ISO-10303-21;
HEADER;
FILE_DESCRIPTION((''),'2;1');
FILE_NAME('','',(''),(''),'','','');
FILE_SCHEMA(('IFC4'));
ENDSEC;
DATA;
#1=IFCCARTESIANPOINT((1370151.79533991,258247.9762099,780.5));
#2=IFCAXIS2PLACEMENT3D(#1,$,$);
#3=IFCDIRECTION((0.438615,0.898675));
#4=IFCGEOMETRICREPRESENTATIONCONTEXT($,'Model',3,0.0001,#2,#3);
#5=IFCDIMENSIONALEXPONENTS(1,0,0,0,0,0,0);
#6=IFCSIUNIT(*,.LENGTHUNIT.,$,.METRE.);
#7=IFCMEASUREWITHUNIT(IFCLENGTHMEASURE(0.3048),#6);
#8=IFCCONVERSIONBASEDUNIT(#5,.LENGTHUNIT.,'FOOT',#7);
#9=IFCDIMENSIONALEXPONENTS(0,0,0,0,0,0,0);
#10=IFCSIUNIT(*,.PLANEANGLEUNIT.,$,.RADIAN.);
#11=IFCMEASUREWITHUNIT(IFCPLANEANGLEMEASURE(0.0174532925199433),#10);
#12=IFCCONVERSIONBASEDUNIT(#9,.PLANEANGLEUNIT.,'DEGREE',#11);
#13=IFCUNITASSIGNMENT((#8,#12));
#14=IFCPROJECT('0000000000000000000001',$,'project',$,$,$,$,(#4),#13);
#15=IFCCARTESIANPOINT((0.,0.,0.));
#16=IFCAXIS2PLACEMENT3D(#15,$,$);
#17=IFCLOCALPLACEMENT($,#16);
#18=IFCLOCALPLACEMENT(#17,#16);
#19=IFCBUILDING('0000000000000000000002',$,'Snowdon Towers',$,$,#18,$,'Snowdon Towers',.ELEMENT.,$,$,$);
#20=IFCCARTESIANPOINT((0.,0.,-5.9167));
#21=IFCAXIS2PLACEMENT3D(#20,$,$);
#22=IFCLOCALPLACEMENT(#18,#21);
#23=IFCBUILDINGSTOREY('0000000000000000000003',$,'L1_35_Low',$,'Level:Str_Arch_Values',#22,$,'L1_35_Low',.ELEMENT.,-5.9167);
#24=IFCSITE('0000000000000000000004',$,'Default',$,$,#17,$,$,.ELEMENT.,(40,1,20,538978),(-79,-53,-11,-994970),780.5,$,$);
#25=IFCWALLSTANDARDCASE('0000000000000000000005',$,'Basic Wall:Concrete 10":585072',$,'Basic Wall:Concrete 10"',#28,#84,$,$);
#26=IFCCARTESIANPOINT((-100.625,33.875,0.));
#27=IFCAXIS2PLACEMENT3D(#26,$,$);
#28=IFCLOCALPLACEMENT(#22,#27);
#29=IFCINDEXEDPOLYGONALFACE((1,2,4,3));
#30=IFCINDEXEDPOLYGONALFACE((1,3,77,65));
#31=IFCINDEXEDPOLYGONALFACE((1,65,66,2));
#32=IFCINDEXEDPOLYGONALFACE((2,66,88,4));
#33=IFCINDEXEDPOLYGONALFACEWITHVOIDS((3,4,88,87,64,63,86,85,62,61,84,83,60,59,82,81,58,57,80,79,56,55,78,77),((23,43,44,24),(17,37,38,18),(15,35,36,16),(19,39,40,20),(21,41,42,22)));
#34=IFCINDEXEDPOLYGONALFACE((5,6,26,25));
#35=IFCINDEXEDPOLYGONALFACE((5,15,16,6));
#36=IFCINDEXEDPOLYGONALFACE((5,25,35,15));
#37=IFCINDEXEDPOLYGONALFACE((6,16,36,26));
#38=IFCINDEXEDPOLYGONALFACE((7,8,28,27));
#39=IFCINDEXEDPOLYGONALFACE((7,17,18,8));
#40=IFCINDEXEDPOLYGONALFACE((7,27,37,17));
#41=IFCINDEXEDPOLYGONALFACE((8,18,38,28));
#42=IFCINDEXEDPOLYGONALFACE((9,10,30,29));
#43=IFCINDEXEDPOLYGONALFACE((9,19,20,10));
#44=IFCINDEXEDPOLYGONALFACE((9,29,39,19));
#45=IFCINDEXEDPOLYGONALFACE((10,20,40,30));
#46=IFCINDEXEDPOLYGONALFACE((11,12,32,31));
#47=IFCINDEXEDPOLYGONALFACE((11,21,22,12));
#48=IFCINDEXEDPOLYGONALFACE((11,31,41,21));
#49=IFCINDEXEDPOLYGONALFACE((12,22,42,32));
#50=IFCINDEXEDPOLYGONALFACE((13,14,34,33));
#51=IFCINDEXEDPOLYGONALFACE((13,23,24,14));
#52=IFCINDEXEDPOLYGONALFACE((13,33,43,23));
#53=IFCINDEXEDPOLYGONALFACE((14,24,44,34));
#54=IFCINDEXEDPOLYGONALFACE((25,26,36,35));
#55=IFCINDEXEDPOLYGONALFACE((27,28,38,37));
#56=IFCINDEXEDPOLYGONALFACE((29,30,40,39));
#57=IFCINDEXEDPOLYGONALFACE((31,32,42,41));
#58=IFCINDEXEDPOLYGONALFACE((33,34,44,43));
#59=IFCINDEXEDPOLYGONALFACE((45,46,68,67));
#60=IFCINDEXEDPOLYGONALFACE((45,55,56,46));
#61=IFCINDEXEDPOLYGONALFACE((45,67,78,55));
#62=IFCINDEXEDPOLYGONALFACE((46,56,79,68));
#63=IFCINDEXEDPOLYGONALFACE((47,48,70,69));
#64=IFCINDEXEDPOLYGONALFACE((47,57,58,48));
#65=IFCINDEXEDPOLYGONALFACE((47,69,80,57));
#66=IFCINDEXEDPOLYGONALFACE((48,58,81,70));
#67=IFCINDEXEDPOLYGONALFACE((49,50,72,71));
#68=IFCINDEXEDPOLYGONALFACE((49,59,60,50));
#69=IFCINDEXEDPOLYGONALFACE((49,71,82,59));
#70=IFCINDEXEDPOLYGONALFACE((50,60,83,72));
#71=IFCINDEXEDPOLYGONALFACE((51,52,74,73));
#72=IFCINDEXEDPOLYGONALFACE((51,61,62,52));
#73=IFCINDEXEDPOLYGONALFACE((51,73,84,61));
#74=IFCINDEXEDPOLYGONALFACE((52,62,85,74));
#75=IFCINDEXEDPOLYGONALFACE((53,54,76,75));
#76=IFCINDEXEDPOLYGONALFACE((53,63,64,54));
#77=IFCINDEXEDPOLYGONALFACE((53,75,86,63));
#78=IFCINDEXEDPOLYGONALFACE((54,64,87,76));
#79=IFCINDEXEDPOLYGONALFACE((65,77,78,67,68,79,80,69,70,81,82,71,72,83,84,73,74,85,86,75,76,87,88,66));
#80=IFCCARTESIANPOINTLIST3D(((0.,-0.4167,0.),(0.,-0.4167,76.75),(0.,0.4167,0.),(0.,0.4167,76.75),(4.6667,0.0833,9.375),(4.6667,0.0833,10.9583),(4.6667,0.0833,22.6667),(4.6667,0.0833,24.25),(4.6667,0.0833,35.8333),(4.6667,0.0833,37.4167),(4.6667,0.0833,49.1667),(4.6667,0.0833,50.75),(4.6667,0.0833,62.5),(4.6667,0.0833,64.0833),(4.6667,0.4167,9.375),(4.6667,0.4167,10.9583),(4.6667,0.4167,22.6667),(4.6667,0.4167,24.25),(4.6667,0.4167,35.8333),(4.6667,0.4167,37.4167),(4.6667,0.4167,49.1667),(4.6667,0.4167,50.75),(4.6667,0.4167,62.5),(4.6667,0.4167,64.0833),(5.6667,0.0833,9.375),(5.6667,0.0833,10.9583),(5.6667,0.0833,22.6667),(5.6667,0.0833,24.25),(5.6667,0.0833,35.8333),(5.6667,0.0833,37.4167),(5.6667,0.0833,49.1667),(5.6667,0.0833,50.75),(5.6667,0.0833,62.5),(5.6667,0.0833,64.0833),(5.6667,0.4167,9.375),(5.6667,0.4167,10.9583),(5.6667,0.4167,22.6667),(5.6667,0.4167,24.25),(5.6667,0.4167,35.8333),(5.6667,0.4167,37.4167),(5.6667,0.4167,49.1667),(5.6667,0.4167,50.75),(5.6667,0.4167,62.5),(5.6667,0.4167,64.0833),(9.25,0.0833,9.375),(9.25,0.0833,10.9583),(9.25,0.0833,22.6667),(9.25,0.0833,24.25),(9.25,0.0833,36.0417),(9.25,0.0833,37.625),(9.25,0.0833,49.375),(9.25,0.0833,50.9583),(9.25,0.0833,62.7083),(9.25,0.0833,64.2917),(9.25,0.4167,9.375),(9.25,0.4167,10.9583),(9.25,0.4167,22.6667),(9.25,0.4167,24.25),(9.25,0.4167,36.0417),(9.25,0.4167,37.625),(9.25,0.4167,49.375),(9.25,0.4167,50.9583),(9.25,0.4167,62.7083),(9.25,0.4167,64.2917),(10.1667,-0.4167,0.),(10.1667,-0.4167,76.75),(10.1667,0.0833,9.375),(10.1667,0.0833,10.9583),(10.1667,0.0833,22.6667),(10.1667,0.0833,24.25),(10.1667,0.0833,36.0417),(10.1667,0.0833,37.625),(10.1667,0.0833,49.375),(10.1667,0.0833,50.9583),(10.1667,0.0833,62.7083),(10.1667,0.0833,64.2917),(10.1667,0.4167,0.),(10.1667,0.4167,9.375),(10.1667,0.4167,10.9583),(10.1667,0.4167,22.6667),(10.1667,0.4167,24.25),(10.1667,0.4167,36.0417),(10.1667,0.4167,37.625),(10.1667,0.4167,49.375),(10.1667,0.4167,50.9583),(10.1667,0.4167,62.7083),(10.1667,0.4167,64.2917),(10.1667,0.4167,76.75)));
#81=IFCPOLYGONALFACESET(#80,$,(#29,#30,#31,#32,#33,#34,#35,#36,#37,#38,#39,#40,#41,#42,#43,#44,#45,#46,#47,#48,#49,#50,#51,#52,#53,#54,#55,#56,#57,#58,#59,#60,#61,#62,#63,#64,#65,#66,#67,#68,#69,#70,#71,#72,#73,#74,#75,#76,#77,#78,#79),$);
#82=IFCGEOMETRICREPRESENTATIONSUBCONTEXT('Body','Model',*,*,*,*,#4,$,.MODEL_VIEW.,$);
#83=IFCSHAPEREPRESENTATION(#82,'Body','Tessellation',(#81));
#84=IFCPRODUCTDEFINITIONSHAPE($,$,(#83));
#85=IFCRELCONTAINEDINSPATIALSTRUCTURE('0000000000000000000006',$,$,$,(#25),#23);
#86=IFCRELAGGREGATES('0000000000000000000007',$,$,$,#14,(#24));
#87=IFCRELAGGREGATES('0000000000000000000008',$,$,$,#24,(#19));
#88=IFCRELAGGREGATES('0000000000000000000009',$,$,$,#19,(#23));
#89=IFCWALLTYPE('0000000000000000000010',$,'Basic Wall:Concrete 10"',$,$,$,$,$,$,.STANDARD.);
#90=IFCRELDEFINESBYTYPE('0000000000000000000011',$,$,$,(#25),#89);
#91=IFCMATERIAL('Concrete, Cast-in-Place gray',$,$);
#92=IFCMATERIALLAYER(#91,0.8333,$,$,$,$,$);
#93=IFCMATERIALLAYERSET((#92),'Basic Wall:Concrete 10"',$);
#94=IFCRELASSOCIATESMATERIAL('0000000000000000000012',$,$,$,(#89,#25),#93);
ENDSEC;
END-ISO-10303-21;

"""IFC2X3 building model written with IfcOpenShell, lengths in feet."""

from ifc_helpers import new_model, entity, si_unit, converted_unit, direction, frame, frame_2d, origin, place, context, subcontext, project, spatial, rectangle, extrude, material, layer, layer_set, layer_usage, type_object, element, save


model = new_model("IFC2X3")

# Units and contexts
model_context = context("Model", 3, precision=0.0001, world=frame((1370151.79533991, 258247.9762099, 780.5)), true_north=direction((0.438615, 0.898675)))
body_context = subcontext(model_context, "Body", "Model", "MODEL_VIEW")
ifc_project = project(units=[converted_unit("LENGTHUNIT", "FOOT", entity("IfcLengthMeasure", 0.3048), si_unit("LENGTHUNIT", "METRE"), dimensions=[1, 0, 0, 0, 0, 0, 0]), converted_unit("PLANEANGLEUNIT", "DEGREE", entity("IfcPlaneAngleMeasure", 0.0174532925199433), si_unit("PLANEANGLEUNIT", "RADIAN"), dimensions=[0, 0, 0, 0, 0, 0, 0])], contexts=[model_context])

# Site, building, storey
site_placement = place(None, origin())
site = spatial("IfcSite", under=ifc_project, at=site_placement, Name="Default", CompositionType="ELEMENT", RefLatitude=(40, 1, 20, 538978), RefLongitude=(-79, -53, -11, -994970), RefElevation=780.5)
building_placement = place(site_placement, origin())
building = spatial("IfcBuilding", under=site, at=building_placement, Name="Snowdon Towers", LongName="Snowdon Towers", CompositionType="ELEMENT")
storey_placement = place(building_placement, frame((0.0, 0.0, -5.9167)))
storey = spatial("IfcBuildingStorey", under=building, at=storey_placement, Name="L1_35_Low", ObjectType="Level:Str_Arch_Values", LongName="L1_35_Low", CompositionType="ELEMENT", Elevation=-5.9167)

# Wall, openings
ifc_material_1 = material(Name="Concrete, Cast-in-Place gray")
ifc_layer = layer(ifc_material_1, 0.8333)
ifc_layer_set = layer_set([ifc_layer], Name="Basic Wall:Concrete 10\"")
ifc_layer_usage_1 = layer_usage(ifc_layer_set, "AXIS2", "POSITIVE", -0.4167)
wall_type = type_object("IfcWallType", Name="Basic Wall:Concrete 10\"", PredefinedType="STANDARD", material=ifc_layer_set)
wall_1_placement = place(storey_placement, frame((-100.625, 33.875, 0.0)))
wall_1 = element("IfcWallStandardCase", 1, at=wall_1_placement, inside=storey, type_object=wall_type, material=ifc_layer_usage_1, Name="Basic Wall:Concrete 10\":585072", ObjectType="Basic Wall:Concrete 10\"", context=body_context, shape_type="SweptSolid", body=[
    extrude(rectangle(XDim=10.1667, YDim=0.8333, at=frame_2d((5.0833, 0.0), x_axis=(-1.0, 0.0))), origin(), (0.0, 0.0, 1.0), 76.75),
])
opening_1_placement = place(wall_1_placement, origin())
element("IfcOpeningElement", 2, at=opening_1_placement, cuts=wall_1, ObjectType="Recess", context=body_context, shape_type="SweptSolid", body=[
    extrude(rectangle(XDim=1.5833, YDim=1.0, at=frame_2d((0.0, 0.0), x_axis=(0.0, 1.0))), frame((9.75, 0.0833, 23.4583), z_axis=(0.0, 1.0, 0.0), x_axis=(1.0, 0.0, 0.0)), (0.0, 0.0, 1.0), 0.3333),
])
opening_2_placement = place(wall_1_placement, origin())
element("IfcOpeningElement", 3, at=opening_2_placement, cuts=wall_1, ObjectType="Recess", context=body_context, shape_type="SweptSolid", body=[
    extrude(rectangle(XDim=1.5833, YDim=1.0, at=frame_2d((0.0, 0.0), x_axis=(0.0, 1.0))), frame((9.75, 0.0833, 10.1667), z_axis=(0.0, 1.0, 0.0), x_axis=(1.0, 0.0, 0.0)), (0.0, 0.0, 1.0), 0.3333),
])
opening_3_placement = place(wall_1_placement, origin())
element("IfcOpeningElement", 4, at=opening_3_placement, cuts=wall_1, ObjectType="Recess", context=body_context, shape_type="SweptSolid", body=[
    extrude(rectangle(XDim=1.5833, YDim=1.0, at=frame_2d((0.0, 0.0), x_axis=(0.0, 1.0))), frame((9.75, 0.0833, 63.5), z_axis=(0.0, 1.0, 0.0), x_axis=(1.0, 0.0, 0.0)), (0.0, 0.0, 1.0), 0.3333),
])
opening_4_placement = place(wall_1_placement, origin())
element("IfcOpeningElement", 5, at=opening_4_placement, cuts=wall_1, ObjectType="Recess", context=body_context, shape_type="SweptSolid", body=[
    extrude(rectangle(XDim=1.5833, YDim=1.0, at=frame_2d((0.0, 0.0), x_axis=(0.0, 1.0))), frame((9.75, 0.0833, 36.8333), z_axis=(0.0, 1.0, 0.0), x_axis=(1.0, 0.0, 0.0)), (0.0, 0.0, 1.0), 0.3333),
])
opening_5_placement = place(wall_1_placement, origin())
element("IfcOpeningElement", 6, at=opening_5_placement, cuts=wall_1, ObjectType="Recess", context=body_context, shape_type="SweptSolid", body=[
    extrude(rectangle(XDim=1.5833, YDim=1.0, at=frame_2d((0.0, 0.0), x_axis=(0.0, 1.0))), frame((9.75, 0.0833, 50.1667), z_axis=(0.0, 1.0, 0.0), x_axis=(1.0, 0.0, 0.0)), (0.0, 0.0, 1.0), 0.3333),
])
opening_6_placement = place(wall_1_placement, origin())
element("IfcOpeningElement", 7, at=opening_6_placement, cuts=wall_1, ObjectType="Recess", context=body_context, shape_type="SweptSolid", body=[
    extrude(rectangle(XDim=1.5833, YDim=1.0, at=frame_2d((0.0, 0.0), x_axis=(0.0, 1.0))), frame((5.1667, 0.0833, 23.4583), z_axis=(0.0, 1.0, 0.0), x_axis=(1.0, 0.0, 0.0)), (0.0, 0.0, 1.0), 0.3333),
])
opening_7_placement = place(wall_1_placement, origin())
element("IfcOpeningElement", 8, at=opening_7_placement, cuts=wall_1, ObjectType="Recess", context=body_context, shape_type="SweptSolid", body=[
    extrude(rectangle(XDim=1.5833, YDim=1.0, at=frame_2d((0.0, 0.0), x_axis=(0.0, 1.0))), frame((5.1667, 0.0833, 10.1667), z_axis=(0.0, 1.0, 0.0), x_axis=(1.0, 0.0, 0.0)), (0.0, 0.0, 1.0), 0.3333),
])
opening_8_placement = place(wall_1_placement, origin())
element("IfcOpeningElement", 9, at=opening_8_placement, cuts=wall_1, ObjectType="Recess", context=body_context, shape_type="SweptSolid", body=[
    extrude(rectangle(XDim=1.5833, YDim=1.0, at=frame_2d((0.0, 0.0), x_axis=(0.0, 1.0))), frame((5.1667, 0.0833, 63.2917), z_axis=(0.0, 1.0, 0.0), x_axis=(1.0, 0.0, 0.0)), (0.0, 0.0, 1.0), 0.3333),
])
opening_9_placement = place(wall_1_placement, origin())
element("IfcOpeningElement", 10, at=opening_9_placement, cuts=wall_1, ObjectType="Recess", context=body_context, shape_type="SweptSolid", body=[
    extrude(rectangle(XDim=1.5833, YDim=1.0, at=frame_2d((0.0, 0.0), x_axis=(0.0, 1.0))), frame((5.1667, 0.0833, 36.625), z_axis=(0.0, 1.0, 0.0), x_axis=(1.0, 0.0, 0.0)), (0.0, 0.0, 1.0), 0.3333),
])
opening_10_placement = place(wall_1_placement, origin())
element("IfcOpeningElement", 11, at=opening_10_placement, cuts=wall_1, ObjectType="Recess", context=body_context, shape_type="SweptSolid", body=[
    extrude(rectangle(XDim=1.5833, YDim=1.0, at=frame_2d((0.0, 0.0), x_axis=(0.0, 1.0))), frame((5.1667, 0.0833, 49.9583), z_axis=(0.0, 1.0, 0.0), x_axis=(1.0, 0.0, 0.0)), (0.0, 0.0, 1.0), 0.3333),
])

save(model, "model.ifc")
